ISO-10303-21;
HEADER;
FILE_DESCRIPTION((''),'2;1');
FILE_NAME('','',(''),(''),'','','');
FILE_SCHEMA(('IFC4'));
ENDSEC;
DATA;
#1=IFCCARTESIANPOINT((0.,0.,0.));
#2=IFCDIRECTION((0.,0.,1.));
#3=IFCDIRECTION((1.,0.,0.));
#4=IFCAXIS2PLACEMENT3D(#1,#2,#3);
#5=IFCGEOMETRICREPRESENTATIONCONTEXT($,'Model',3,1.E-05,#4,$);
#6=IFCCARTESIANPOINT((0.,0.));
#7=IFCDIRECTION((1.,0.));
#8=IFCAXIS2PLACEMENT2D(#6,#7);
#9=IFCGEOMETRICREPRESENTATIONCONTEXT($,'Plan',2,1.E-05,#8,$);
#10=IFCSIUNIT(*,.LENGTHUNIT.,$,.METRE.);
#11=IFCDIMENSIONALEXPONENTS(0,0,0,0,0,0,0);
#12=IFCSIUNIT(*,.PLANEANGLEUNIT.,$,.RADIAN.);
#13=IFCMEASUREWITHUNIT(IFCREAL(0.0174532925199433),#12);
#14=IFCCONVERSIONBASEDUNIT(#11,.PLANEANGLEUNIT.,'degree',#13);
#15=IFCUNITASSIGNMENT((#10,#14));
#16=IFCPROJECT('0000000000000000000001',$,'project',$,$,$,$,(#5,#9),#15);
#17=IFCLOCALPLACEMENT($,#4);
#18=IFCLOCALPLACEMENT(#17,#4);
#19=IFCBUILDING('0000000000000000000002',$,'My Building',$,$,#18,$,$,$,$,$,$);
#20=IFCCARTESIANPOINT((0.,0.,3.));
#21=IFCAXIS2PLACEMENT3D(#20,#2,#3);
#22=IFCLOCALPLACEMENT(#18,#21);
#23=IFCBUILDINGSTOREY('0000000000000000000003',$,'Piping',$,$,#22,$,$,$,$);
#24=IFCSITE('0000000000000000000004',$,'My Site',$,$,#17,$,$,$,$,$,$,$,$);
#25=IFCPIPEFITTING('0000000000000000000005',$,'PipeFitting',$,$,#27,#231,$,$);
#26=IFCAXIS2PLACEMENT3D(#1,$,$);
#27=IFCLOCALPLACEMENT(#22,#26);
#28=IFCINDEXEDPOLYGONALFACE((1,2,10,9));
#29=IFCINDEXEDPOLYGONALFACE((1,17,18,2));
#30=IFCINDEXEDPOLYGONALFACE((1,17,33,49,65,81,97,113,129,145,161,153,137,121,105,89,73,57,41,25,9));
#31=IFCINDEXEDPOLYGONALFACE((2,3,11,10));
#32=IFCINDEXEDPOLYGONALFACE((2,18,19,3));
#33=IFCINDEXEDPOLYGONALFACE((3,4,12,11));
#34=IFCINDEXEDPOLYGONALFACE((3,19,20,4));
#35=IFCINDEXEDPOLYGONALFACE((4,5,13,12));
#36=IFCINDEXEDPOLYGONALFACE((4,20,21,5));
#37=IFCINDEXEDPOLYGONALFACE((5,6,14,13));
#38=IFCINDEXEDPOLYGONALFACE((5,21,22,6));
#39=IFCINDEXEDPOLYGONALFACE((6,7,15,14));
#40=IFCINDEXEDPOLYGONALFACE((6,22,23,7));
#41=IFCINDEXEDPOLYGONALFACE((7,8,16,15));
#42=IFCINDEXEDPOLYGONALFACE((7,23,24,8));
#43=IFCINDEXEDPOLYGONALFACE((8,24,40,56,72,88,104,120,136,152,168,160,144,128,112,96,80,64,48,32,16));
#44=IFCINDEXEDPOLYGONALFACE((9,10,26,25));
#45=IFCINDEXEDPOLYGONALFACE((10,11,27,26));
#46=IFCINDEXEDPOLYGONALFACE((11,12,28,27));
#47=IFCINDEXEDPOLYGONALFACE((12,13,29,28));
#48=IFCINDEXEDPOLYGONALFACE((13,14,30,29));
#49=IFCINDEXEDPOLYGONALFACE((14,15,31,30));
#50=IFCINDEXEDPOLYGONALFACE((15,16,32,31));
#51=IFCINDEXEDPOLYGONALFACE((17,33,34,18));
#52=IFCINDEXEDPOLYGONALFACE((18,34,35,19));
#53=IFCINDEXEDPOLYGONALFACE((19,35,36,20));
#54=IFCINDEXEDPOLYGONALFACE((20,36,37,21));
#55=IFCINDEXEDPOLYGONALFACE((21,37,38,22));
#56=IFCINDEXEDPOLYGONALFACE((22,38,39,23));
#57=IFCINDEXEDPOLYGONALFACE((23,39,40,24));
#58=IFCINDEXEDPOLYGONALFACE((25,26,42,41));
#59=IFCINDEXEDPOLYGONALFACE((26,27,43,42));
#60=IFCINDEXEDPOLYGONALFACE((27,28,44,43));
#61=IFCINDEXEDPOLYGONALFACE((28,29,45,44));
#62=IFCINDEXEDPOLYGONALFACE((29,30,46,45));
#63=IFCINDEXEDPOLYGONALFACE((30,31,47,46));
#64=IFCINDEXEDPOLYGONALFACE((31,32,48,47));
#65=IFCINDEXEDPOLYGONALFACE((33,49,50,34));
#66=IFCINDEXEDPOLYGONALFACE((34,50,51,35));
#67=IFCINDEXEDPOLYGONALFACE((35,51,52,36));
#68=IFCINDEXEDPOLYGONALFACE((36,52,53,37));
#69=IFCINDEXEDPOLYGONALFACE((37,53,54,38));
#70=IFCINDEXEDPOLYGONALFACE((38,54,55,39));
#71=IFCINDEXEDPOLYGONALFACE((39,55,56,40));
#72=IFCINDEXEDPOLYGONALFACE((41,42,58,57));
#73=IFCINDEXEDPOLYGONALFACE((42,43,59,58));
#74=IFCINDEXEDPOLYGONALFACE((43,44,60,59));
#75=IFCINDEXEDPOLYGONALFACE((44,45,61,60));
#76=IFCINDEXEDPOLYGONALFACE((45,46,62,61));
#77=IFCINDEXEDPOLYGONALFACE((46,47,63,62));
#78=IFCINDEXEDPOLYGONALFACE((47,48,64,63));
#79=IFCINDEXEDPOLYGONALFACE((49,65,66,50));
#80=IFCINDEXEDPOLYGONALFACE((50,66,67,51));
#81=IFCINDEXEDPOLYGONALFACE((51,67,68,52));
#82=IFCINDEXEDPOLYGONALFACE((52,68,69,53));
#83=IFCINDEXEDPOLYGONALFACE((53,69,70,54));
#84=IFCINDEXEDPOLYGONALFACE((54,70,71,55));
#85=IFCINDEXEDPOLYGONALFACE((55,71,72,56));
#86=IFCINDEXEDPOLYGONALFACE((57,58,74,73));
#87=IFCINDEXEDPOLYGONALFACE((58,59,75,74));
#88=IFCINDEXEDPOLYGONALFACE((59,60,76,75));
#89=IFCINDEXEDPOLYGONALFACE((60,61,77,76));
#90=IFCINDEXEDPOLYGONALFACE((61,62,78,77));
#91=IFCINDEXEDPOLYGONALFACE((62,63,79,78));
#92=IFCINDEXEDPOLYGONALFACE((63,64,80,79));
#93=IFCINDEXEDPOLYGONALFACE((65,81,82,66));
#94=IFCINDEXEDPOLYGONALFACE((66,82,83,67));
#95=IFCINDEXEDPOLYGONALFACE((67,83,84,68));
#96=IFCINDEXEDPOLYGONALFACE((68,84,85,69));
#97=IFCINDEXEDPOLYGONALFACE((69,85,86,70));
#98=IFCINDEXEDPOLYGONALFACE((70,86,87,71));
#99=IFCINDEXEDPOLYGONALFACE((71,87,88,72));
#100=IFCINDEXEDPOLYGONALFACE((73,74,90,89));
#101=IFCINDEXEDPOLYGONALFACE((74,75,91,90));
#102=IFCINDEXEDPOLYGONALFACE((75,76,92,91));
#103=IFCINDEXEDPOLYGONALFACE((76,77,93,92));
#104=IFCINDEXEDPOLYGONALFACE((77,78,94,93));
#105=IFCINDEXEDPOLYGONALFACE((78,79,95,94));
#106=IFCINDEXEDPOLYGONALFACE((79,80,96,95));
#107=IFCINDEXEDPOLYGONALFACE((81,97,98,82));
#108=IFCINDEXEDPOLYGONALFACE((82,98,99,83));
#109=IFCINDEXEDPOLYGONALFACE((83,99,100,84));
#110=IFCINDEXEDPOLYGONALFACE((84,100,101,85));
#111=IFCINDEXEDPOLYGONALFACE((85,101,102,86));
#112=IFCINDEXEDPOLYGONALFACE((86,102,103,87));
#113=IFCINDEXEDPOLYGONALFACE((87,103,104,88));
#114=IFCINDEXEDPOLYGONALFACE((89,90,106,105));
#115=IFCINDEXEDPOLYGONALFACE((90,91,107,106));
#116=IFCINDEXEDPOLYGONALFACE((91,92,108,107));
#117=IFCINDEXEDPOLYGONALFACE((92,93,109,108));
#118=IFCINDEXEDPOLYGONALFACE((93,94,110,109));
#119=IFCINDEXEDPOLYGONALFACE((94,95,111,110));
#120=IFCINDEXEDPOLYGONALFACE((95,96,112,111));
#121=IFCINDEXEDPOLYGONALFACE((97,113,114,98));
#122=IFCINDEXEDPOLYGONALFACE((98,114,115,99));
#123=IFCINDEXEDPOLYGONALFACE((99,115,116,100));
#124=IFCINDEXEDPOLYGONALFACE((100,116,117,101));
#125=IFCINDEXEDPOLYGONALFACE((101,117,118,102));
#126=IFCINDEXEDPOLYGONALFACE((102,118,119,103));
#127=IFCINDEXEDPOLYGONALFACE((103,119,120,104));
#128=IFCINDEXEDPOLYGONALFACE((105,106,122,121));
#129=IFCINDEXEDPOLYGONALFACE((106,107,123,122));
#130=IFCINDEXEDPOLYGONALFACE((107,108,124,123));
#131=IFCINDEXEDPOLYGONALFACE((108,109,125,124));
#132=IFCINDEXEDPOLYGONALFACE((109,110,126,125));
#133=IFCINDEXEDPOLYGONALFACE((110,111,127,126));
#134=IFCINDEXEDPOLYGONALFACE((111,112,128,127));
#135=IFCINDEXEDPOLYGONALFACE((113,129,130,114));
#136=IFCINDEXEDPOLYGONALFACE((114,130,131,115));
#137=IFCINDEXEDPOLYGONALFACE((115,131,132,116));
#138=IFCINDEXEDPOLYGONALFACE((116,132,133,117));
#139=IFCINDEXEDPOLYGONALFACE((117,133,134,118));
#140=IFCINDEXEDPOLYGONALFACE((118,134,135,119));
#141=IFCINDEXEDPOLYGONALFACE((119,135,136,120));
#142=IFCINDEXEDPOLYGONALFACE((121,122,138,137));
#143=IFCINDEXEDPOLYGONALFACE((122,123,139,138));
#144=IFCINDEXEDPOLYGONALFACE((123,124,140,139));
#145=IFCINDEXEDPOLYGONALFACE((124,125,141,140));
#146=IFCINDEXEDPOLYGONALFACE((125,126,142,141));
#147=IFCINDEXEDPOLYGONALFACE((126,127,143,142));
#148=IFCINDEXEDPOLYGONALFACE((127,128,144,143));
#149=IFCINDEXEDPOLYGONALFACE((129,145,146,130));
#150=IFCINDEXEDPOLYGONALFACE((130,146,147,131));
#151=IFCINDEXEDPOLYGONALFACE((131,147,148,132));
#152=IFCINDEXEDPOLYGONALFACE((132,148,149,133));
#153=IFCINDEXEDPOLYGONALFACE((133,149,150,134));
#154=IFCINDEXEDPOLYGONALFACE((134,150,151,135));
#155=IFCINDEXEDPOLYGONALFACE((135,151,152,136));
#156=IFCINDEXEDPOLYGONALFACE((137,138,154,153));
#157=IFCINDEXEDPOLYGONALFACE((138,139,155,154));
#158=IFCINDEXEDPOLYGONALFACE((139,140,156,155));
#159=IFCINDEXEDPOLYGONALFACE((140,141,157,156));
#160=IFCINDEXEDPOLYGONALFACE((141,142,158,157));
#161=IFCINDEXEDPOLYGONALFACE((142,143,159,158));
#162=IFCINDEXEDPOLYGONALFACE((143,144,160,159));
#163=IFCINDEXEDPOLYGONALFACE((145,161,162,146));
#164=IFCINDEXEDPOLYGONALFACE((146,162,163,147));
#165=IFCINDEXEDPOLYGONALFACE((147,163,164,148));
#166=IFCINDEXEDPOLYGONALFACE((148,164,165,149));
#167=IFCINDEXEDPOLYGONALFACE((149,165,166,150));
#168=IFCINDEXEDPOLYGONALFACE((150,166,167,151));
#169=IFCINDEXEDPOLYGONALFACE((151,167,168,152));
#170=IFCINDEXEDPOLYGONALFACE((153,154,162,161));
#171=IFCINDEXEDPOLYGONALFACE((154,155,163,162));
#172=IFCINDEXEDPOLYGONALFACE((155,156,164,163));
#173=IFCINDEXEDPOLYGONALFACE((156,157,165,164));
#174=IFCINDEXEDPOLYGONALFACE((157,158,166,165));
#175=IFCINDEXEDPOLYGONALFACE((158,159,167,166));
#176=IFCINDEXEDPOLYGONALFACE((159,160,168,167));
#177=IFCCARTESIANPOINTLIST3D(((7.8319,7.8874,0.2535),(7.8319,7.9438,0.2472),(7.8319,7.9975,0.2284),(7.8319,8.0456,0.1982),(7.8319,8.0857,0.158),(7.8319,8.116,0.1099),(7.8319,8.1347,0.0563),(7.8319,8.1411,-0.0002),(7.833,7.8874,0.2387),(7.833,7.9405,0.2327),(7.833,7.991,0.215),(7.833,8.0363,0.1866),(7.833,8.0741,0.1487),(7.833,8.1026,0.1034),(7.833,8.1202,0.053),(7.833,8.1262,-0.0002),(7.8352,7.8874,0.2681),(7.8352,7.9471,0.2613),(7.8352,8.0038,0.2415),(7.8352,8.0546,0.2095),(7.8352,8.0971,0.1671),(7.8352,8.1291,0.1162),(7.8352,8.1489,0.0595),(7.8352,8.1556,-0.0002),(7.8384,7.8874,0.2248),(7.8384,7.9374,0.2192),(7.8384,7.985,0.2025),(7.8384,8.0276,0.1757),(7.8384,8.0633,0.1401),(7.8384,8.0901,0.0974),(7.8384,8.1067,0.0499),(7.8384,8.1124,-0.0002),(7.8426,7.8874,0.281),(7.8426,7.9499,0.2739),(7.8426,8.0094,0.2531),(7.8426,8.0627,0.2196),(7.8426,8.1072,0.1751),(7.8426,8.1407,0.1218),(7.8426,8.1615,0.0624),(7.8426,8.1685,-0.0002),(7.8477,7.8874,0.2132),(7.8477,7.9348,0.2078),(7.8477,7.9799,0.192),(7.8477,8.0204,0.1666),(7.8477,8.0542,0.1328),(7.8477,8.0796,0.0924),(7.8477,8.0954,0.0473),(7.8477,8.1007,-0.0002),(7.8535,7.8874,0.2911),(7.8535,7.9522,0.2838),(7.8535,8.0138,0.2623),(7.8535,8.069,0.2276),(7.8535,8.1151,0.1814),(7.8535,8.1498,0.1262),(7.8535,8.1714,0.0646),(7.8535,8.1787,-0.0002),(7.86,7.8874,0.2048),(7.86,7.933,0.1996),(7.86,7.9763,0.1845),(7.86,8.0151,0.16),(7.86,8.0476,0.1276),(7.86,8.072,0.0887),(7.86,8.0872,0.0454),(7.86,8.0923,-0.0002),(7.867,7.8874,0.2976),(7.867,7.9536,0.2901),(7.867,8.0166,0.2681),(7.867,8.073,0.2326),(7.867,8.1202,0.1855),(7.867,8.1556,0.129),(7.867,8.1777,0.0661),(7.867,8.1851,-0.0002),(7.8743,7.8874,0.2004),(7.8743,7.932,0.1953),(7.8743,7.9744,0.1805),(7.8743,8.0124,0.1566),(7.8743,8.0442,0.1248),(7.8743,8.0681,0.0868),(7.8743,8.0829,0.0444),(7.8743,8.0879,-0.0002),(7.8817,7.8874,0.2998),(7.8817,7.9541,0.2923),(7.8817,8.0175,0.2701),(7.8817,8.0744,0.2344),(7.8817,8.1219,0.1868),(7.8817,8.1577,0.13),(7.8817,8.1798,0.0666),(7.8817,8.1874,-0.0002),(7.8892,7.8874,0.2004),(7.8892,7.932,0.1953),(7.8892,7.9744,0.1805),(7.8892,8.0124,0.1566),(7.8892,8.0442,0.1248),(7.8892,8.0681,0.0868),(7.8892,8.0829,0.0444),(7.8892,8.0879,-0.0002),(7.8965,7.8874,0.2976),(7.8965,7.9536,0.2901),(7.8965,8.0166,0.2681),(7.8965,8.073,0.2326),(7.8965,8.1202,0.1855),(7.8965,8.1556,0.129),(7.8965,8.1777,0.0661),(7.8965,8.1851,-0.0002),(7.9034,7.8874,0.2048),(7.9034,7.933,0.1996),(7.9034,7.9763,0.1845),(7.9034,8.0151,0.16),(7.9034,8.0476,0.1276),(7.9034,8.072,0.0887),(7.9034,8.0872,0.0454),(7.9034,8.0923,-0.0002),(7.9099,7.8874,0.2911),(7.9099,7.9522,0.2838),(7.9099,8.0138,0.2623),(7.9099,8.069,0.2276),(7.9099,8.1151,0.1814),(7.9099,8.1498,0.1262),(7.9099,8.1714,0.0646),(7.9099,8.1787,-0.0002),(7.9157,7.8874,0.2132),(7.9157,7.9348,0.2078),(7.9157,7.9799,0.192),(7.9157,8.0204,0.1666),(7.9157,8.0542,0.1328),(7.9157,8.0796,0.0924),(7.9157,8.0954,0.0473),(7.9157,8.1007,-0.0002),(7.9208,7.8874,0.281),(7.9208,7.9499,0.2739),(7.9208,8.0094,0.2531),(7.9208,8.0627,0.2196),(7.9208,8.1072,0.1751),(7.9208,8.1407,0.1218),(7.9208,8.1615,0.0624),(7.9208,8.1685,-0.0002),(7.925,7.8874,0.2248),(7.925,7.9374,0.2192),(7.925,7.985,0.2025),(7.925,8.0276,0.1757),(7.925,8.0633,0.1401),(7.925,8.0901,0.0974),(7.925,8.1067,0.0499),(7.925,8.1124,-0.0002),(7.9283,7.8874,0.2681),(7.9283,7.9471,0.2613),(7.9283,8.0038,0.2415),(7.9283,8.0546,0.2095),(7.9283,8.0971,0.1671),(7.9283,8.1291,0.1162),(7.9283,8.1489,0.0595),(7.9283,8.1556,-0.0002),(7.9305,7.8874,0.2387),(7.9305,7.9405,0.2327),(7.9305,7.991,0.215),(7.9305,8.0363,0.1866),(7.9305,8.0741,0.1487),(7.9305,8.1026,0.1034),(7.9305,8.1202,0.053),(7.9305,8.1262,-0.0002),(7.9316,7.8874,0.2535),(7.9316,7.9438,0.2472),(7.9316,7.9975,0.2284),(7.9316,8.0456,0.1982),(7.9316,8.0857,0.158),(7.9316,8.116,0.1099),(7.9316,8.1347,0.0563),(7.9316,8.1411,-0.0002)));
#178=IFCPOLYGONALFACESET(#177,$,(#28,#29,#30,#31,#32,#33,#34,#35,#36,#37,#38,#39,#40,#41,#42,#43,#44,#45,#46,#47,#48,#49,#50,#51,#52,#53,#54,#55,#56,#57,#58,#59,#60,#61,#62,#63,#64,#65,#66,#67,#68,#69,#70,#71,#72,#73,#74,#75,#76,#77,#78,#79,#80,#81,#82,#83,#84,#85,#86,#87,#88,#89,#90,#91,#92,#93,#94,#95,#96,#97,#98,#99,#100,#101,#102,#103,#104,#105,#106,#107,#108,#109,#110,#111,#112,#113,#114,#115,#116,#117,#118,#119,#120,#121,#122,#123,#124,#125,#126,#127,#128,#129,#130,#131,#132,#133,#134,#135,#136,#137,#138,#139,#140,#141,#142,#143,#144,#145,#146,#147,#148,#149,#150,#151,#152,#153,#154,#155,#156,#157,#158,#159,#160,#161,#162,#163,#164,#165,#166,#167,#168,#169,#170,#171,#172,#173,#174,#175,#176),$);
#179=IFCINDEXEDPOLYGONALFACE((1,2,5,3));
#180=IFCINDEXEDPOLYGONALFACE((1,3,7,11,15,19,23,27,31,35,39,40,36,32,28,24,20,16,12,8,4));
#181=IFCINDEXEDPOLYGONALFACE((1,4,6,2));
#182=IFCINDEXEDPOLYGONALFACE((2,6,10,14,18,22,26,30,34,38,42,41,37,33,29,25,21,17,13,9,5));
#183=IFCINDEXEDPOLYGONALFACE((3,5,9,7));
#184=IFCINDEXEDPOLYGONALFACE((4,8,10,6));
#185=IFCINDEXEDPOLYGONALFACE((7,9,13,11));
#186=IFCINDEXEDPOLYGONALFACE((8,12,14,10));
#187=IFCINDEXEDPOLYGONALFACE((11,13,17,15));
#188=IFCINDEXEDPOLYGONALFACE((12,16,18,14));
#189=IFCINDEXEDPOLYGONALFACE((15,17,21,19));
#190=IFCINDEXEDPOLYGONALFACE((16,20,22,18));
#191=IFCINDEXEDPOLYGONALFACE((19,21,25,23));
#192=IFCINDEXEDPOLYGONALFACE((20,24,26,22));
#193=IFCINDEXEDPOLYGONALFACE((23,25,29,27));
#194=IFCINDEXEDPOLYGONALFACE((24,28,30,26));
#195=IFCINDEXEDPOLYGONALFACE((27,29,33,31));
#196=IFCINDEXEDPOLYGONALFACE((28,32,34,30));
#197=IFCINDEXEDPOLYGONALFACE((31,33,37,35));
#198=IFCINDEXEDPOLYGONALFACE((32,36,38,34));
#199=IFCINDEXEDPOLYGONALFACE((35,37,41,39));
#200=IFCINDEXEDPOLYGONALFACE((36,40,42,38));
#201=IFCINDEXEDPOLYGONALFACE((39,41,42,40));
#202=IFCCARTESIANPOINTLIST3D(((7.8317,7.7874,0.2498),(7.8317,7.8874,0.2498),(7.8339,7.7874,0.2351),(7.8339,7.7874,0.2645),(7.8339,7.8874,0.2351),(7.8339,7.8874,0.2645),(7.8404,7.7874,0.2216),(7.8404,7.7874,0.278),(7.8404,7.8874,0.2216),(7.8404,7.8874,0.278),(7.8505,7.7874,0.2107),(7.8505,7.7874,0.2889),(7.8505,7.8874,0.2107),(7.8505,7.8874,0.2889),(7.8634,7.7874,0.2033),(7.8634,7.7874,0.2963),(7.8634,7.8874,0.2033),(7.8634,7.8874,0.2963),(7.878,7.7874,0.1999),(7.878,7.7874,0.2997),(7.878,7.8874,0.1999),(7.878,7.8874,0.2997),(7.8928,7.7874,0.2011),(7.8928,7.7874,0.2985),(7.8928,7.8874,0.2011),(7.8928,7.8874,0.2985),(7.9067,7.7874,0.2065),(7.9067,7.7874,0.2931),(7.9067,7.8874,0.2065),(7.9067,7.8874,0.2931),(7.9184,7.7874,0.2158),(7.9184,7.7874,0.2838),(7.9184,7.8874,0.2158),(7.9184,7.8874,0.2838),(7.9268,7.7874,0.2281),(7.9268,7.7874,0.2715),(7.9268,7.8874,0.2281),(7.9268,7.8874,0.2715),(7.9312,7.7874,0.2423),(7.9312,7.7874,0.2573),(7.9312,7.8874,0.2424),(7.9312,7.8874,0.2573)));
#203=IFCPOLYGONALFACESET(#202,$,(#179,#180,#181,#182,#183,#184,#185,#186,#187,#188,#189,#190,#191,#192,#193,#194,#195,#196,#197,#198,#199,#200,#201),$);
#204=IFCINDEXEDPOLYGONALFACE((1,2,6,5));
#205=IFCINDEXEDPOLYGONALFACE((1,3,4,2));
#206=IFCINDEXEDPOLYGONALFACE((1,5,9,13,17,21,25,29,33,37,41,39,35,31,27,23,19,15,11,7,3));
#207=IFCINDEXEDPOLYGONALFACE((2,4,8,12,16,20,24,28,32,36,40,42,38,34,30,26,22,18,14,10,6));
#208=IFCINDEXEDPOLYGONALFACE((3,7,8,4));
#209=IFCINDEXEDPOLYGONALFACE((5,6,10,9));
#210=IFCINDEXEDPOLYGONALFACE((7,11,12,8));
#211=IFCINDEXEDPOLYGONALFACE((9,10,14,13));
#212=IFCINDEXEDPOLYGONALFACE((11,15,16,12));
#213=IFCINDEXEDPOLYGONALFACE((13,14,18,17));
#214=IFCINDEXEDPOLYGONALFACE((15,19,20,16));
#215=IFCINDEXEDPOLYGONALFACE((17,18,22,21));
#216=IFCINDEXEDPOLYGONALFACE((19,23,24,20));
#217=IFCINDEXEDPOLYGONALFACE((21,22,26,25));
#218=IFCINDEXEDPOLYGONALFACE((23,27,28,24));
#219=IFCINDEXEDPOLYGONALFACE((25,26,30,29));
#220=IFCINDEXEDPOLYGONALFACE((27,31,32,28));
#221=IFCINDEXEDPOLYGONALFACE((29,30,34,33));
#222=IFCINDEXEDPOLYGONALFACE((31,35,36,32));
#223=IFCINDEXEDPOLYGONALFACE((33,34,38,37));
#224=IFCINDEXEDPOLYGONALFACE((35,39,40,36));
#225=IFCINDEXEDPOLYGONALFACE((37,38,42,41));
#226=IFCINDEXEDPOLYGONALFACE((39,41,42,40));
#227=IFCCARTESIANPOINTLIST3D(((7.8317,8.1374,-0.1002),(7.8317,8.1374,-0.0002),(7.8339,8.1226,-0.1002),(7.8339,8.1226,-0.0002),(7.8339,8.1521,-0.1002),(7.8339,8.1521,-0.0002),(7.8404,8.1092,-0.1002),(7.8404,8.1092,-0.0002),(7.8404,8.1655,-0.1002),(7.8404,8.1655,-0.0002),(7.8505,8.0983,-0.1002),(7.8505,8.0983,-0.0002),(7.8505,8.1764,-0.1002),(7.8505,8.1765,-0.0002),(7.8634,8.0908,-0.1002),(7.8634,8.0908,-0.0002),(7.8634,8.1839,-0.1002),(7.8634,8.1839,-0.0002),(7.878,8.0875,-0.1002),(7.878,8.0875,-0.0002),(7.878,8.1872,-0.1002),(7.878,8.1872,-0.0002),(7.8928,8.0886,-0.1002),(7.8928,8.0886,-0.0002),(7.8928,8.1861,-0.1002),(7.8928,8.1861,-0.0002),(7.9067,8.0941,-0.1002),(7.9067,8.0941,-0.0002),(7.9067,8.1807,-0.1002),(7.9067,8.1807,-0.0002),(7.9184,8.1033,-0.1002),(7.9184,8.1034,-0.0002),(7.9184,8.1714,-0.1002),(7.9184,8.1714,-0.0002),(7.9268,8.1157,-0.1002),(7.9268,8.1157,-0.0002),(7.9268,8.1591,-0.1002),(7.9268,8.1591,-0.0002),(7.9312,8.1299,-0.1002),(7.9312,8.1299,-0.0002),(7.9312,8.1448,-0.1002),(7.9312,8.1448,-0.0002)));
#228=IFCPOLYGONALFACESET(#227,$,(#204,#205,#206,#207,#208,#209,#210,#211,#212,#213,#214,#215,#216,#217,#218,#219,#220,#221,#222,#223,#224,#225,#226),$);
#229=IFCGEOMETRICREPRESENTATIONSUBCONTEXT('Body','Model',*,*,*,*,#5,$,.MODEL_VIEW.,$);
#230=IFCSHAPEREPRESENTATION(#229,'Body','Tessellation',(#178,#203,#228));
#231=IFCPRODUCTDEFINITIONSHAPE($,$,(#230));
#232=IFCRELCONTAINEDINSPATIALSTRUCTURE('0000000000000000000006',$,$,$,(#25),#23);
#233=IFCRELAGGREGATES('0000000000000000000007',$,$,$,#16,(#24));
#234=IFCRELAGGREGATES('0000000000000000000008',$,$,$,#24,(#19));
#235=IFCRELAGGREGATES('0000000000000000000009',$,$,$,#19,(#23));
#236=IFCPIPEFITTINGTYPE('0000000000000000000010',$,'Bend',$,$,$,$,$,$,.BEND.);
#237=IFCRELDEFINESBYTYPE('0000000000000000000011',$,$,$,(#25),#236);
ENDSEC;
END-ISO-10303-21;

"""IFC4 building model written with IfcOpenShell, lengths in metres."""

from ifc_helpers import new_model, entity, si_unit, converted_unit, frame, origin_with_axes, origin_2d_with_axis, place, context, subcontext, project, spatial, circle, extrude, source, transform, mapped, type_object, type_shapes, element, save


model = new_model("IFC4")

# Units and contexts
model_context = context("Model", 3, precision=1e-05, world=origin_with_axes())
plan_context = context("Plan", 2, precision=1e-05, world=origin_2d_with_axis())
body_context = subcontext(model_context, "Body", "Model", "MODEL_VIEW")
ifc_project = project(units=[si_unit("LENGTHUNIT", "METRE"), converted_unit("PLANEANGLEUNIT", "degree", entity("IfcReal", 0.0174532925199433), si_unit("PLANEANGLEUNIT", "RADIAN"), dimensions=[0, 0, 0, 0, 0, 0, 0])], contexts=[model_context, plan_context])

# Site, building, storey
site_placement = place(None, origin_with_axes())
site = spatial("IfcSite", under=ifc_project, at=site_placement, Name="My Site")
building_placement = place(site_placement, origin_with_axes())
building = spatial("IfcBuilding", under=site, at=building_placement, Name="My Building")
storey_placement = place(building_placement, frame((0.0, 0.0, 3.0), z_axis=(0.0, 0.0, 1.0), x_axis=(1.0, 0.0, 0.0)))
storey = spatial("IfcBuildingStorey", under=building, at=storey_placement, Name="Piping")

# Pipe fitting
pipe_fitting_type_1 = type_object("IfcPipeFittingType", Name="Bend", PredefinedType="BEND")
shared_shape = source(origin_with_axes(), body_context, "Body", "SolidModel", [
    entity("IfcSweptDiskSolid", entity("IfcIndexedPolyCurve", entity("IfcCartesianPointList3D", [[0.0, 0.0, 0.1], [0.0, -0.0732, 0.2768], [0.0, -0.25, 0.35]]), [entity("IfcArcIndex", [1, 2, 3])]), 0.05),
    extrude(circle(Radius=0.05), origin_with_axes(), (0.0, 0.0, 1.0), 0.1),
    extrude(circle(Radius=0.05), frame((0.0, -0.25, 0.35), z_axis=(0.0, -1.0, -0.00003), x_axis=(1.0, 0.0, 0.0)), (0.0, 0.0, 1.0), 0.1),
])
type_shapes(pipe_fitting_type_1, [shared_shape])
for number, where, z_axis, x_axis, name in (
    (1, (7.8817, 7.7874, 0.2498), (0.0, 1.0, 0.000008), (-1.0, 0.0, 0.0), "PipeFitting"),
):
    element("IfcPipeFitting", number, at=place(storey_placement, frame(where, z_axis=z_axis, x_axis=x_axis)), inside=storey, type_object=pipe_fitting_type_1, Name=name, context=body_context, shape_type="MappedRepresentation", body=[
        mapped(shared_shape, transform((0.0, 0.0, 0.0), x_axis=(1.0, 0.0, 0.0), y_axis=(0.0, 1.0, 0.0), z_axis=(0.0, 0.0, 1.0), scale=1.0)),
    ])

save(model, "model.ifc")
